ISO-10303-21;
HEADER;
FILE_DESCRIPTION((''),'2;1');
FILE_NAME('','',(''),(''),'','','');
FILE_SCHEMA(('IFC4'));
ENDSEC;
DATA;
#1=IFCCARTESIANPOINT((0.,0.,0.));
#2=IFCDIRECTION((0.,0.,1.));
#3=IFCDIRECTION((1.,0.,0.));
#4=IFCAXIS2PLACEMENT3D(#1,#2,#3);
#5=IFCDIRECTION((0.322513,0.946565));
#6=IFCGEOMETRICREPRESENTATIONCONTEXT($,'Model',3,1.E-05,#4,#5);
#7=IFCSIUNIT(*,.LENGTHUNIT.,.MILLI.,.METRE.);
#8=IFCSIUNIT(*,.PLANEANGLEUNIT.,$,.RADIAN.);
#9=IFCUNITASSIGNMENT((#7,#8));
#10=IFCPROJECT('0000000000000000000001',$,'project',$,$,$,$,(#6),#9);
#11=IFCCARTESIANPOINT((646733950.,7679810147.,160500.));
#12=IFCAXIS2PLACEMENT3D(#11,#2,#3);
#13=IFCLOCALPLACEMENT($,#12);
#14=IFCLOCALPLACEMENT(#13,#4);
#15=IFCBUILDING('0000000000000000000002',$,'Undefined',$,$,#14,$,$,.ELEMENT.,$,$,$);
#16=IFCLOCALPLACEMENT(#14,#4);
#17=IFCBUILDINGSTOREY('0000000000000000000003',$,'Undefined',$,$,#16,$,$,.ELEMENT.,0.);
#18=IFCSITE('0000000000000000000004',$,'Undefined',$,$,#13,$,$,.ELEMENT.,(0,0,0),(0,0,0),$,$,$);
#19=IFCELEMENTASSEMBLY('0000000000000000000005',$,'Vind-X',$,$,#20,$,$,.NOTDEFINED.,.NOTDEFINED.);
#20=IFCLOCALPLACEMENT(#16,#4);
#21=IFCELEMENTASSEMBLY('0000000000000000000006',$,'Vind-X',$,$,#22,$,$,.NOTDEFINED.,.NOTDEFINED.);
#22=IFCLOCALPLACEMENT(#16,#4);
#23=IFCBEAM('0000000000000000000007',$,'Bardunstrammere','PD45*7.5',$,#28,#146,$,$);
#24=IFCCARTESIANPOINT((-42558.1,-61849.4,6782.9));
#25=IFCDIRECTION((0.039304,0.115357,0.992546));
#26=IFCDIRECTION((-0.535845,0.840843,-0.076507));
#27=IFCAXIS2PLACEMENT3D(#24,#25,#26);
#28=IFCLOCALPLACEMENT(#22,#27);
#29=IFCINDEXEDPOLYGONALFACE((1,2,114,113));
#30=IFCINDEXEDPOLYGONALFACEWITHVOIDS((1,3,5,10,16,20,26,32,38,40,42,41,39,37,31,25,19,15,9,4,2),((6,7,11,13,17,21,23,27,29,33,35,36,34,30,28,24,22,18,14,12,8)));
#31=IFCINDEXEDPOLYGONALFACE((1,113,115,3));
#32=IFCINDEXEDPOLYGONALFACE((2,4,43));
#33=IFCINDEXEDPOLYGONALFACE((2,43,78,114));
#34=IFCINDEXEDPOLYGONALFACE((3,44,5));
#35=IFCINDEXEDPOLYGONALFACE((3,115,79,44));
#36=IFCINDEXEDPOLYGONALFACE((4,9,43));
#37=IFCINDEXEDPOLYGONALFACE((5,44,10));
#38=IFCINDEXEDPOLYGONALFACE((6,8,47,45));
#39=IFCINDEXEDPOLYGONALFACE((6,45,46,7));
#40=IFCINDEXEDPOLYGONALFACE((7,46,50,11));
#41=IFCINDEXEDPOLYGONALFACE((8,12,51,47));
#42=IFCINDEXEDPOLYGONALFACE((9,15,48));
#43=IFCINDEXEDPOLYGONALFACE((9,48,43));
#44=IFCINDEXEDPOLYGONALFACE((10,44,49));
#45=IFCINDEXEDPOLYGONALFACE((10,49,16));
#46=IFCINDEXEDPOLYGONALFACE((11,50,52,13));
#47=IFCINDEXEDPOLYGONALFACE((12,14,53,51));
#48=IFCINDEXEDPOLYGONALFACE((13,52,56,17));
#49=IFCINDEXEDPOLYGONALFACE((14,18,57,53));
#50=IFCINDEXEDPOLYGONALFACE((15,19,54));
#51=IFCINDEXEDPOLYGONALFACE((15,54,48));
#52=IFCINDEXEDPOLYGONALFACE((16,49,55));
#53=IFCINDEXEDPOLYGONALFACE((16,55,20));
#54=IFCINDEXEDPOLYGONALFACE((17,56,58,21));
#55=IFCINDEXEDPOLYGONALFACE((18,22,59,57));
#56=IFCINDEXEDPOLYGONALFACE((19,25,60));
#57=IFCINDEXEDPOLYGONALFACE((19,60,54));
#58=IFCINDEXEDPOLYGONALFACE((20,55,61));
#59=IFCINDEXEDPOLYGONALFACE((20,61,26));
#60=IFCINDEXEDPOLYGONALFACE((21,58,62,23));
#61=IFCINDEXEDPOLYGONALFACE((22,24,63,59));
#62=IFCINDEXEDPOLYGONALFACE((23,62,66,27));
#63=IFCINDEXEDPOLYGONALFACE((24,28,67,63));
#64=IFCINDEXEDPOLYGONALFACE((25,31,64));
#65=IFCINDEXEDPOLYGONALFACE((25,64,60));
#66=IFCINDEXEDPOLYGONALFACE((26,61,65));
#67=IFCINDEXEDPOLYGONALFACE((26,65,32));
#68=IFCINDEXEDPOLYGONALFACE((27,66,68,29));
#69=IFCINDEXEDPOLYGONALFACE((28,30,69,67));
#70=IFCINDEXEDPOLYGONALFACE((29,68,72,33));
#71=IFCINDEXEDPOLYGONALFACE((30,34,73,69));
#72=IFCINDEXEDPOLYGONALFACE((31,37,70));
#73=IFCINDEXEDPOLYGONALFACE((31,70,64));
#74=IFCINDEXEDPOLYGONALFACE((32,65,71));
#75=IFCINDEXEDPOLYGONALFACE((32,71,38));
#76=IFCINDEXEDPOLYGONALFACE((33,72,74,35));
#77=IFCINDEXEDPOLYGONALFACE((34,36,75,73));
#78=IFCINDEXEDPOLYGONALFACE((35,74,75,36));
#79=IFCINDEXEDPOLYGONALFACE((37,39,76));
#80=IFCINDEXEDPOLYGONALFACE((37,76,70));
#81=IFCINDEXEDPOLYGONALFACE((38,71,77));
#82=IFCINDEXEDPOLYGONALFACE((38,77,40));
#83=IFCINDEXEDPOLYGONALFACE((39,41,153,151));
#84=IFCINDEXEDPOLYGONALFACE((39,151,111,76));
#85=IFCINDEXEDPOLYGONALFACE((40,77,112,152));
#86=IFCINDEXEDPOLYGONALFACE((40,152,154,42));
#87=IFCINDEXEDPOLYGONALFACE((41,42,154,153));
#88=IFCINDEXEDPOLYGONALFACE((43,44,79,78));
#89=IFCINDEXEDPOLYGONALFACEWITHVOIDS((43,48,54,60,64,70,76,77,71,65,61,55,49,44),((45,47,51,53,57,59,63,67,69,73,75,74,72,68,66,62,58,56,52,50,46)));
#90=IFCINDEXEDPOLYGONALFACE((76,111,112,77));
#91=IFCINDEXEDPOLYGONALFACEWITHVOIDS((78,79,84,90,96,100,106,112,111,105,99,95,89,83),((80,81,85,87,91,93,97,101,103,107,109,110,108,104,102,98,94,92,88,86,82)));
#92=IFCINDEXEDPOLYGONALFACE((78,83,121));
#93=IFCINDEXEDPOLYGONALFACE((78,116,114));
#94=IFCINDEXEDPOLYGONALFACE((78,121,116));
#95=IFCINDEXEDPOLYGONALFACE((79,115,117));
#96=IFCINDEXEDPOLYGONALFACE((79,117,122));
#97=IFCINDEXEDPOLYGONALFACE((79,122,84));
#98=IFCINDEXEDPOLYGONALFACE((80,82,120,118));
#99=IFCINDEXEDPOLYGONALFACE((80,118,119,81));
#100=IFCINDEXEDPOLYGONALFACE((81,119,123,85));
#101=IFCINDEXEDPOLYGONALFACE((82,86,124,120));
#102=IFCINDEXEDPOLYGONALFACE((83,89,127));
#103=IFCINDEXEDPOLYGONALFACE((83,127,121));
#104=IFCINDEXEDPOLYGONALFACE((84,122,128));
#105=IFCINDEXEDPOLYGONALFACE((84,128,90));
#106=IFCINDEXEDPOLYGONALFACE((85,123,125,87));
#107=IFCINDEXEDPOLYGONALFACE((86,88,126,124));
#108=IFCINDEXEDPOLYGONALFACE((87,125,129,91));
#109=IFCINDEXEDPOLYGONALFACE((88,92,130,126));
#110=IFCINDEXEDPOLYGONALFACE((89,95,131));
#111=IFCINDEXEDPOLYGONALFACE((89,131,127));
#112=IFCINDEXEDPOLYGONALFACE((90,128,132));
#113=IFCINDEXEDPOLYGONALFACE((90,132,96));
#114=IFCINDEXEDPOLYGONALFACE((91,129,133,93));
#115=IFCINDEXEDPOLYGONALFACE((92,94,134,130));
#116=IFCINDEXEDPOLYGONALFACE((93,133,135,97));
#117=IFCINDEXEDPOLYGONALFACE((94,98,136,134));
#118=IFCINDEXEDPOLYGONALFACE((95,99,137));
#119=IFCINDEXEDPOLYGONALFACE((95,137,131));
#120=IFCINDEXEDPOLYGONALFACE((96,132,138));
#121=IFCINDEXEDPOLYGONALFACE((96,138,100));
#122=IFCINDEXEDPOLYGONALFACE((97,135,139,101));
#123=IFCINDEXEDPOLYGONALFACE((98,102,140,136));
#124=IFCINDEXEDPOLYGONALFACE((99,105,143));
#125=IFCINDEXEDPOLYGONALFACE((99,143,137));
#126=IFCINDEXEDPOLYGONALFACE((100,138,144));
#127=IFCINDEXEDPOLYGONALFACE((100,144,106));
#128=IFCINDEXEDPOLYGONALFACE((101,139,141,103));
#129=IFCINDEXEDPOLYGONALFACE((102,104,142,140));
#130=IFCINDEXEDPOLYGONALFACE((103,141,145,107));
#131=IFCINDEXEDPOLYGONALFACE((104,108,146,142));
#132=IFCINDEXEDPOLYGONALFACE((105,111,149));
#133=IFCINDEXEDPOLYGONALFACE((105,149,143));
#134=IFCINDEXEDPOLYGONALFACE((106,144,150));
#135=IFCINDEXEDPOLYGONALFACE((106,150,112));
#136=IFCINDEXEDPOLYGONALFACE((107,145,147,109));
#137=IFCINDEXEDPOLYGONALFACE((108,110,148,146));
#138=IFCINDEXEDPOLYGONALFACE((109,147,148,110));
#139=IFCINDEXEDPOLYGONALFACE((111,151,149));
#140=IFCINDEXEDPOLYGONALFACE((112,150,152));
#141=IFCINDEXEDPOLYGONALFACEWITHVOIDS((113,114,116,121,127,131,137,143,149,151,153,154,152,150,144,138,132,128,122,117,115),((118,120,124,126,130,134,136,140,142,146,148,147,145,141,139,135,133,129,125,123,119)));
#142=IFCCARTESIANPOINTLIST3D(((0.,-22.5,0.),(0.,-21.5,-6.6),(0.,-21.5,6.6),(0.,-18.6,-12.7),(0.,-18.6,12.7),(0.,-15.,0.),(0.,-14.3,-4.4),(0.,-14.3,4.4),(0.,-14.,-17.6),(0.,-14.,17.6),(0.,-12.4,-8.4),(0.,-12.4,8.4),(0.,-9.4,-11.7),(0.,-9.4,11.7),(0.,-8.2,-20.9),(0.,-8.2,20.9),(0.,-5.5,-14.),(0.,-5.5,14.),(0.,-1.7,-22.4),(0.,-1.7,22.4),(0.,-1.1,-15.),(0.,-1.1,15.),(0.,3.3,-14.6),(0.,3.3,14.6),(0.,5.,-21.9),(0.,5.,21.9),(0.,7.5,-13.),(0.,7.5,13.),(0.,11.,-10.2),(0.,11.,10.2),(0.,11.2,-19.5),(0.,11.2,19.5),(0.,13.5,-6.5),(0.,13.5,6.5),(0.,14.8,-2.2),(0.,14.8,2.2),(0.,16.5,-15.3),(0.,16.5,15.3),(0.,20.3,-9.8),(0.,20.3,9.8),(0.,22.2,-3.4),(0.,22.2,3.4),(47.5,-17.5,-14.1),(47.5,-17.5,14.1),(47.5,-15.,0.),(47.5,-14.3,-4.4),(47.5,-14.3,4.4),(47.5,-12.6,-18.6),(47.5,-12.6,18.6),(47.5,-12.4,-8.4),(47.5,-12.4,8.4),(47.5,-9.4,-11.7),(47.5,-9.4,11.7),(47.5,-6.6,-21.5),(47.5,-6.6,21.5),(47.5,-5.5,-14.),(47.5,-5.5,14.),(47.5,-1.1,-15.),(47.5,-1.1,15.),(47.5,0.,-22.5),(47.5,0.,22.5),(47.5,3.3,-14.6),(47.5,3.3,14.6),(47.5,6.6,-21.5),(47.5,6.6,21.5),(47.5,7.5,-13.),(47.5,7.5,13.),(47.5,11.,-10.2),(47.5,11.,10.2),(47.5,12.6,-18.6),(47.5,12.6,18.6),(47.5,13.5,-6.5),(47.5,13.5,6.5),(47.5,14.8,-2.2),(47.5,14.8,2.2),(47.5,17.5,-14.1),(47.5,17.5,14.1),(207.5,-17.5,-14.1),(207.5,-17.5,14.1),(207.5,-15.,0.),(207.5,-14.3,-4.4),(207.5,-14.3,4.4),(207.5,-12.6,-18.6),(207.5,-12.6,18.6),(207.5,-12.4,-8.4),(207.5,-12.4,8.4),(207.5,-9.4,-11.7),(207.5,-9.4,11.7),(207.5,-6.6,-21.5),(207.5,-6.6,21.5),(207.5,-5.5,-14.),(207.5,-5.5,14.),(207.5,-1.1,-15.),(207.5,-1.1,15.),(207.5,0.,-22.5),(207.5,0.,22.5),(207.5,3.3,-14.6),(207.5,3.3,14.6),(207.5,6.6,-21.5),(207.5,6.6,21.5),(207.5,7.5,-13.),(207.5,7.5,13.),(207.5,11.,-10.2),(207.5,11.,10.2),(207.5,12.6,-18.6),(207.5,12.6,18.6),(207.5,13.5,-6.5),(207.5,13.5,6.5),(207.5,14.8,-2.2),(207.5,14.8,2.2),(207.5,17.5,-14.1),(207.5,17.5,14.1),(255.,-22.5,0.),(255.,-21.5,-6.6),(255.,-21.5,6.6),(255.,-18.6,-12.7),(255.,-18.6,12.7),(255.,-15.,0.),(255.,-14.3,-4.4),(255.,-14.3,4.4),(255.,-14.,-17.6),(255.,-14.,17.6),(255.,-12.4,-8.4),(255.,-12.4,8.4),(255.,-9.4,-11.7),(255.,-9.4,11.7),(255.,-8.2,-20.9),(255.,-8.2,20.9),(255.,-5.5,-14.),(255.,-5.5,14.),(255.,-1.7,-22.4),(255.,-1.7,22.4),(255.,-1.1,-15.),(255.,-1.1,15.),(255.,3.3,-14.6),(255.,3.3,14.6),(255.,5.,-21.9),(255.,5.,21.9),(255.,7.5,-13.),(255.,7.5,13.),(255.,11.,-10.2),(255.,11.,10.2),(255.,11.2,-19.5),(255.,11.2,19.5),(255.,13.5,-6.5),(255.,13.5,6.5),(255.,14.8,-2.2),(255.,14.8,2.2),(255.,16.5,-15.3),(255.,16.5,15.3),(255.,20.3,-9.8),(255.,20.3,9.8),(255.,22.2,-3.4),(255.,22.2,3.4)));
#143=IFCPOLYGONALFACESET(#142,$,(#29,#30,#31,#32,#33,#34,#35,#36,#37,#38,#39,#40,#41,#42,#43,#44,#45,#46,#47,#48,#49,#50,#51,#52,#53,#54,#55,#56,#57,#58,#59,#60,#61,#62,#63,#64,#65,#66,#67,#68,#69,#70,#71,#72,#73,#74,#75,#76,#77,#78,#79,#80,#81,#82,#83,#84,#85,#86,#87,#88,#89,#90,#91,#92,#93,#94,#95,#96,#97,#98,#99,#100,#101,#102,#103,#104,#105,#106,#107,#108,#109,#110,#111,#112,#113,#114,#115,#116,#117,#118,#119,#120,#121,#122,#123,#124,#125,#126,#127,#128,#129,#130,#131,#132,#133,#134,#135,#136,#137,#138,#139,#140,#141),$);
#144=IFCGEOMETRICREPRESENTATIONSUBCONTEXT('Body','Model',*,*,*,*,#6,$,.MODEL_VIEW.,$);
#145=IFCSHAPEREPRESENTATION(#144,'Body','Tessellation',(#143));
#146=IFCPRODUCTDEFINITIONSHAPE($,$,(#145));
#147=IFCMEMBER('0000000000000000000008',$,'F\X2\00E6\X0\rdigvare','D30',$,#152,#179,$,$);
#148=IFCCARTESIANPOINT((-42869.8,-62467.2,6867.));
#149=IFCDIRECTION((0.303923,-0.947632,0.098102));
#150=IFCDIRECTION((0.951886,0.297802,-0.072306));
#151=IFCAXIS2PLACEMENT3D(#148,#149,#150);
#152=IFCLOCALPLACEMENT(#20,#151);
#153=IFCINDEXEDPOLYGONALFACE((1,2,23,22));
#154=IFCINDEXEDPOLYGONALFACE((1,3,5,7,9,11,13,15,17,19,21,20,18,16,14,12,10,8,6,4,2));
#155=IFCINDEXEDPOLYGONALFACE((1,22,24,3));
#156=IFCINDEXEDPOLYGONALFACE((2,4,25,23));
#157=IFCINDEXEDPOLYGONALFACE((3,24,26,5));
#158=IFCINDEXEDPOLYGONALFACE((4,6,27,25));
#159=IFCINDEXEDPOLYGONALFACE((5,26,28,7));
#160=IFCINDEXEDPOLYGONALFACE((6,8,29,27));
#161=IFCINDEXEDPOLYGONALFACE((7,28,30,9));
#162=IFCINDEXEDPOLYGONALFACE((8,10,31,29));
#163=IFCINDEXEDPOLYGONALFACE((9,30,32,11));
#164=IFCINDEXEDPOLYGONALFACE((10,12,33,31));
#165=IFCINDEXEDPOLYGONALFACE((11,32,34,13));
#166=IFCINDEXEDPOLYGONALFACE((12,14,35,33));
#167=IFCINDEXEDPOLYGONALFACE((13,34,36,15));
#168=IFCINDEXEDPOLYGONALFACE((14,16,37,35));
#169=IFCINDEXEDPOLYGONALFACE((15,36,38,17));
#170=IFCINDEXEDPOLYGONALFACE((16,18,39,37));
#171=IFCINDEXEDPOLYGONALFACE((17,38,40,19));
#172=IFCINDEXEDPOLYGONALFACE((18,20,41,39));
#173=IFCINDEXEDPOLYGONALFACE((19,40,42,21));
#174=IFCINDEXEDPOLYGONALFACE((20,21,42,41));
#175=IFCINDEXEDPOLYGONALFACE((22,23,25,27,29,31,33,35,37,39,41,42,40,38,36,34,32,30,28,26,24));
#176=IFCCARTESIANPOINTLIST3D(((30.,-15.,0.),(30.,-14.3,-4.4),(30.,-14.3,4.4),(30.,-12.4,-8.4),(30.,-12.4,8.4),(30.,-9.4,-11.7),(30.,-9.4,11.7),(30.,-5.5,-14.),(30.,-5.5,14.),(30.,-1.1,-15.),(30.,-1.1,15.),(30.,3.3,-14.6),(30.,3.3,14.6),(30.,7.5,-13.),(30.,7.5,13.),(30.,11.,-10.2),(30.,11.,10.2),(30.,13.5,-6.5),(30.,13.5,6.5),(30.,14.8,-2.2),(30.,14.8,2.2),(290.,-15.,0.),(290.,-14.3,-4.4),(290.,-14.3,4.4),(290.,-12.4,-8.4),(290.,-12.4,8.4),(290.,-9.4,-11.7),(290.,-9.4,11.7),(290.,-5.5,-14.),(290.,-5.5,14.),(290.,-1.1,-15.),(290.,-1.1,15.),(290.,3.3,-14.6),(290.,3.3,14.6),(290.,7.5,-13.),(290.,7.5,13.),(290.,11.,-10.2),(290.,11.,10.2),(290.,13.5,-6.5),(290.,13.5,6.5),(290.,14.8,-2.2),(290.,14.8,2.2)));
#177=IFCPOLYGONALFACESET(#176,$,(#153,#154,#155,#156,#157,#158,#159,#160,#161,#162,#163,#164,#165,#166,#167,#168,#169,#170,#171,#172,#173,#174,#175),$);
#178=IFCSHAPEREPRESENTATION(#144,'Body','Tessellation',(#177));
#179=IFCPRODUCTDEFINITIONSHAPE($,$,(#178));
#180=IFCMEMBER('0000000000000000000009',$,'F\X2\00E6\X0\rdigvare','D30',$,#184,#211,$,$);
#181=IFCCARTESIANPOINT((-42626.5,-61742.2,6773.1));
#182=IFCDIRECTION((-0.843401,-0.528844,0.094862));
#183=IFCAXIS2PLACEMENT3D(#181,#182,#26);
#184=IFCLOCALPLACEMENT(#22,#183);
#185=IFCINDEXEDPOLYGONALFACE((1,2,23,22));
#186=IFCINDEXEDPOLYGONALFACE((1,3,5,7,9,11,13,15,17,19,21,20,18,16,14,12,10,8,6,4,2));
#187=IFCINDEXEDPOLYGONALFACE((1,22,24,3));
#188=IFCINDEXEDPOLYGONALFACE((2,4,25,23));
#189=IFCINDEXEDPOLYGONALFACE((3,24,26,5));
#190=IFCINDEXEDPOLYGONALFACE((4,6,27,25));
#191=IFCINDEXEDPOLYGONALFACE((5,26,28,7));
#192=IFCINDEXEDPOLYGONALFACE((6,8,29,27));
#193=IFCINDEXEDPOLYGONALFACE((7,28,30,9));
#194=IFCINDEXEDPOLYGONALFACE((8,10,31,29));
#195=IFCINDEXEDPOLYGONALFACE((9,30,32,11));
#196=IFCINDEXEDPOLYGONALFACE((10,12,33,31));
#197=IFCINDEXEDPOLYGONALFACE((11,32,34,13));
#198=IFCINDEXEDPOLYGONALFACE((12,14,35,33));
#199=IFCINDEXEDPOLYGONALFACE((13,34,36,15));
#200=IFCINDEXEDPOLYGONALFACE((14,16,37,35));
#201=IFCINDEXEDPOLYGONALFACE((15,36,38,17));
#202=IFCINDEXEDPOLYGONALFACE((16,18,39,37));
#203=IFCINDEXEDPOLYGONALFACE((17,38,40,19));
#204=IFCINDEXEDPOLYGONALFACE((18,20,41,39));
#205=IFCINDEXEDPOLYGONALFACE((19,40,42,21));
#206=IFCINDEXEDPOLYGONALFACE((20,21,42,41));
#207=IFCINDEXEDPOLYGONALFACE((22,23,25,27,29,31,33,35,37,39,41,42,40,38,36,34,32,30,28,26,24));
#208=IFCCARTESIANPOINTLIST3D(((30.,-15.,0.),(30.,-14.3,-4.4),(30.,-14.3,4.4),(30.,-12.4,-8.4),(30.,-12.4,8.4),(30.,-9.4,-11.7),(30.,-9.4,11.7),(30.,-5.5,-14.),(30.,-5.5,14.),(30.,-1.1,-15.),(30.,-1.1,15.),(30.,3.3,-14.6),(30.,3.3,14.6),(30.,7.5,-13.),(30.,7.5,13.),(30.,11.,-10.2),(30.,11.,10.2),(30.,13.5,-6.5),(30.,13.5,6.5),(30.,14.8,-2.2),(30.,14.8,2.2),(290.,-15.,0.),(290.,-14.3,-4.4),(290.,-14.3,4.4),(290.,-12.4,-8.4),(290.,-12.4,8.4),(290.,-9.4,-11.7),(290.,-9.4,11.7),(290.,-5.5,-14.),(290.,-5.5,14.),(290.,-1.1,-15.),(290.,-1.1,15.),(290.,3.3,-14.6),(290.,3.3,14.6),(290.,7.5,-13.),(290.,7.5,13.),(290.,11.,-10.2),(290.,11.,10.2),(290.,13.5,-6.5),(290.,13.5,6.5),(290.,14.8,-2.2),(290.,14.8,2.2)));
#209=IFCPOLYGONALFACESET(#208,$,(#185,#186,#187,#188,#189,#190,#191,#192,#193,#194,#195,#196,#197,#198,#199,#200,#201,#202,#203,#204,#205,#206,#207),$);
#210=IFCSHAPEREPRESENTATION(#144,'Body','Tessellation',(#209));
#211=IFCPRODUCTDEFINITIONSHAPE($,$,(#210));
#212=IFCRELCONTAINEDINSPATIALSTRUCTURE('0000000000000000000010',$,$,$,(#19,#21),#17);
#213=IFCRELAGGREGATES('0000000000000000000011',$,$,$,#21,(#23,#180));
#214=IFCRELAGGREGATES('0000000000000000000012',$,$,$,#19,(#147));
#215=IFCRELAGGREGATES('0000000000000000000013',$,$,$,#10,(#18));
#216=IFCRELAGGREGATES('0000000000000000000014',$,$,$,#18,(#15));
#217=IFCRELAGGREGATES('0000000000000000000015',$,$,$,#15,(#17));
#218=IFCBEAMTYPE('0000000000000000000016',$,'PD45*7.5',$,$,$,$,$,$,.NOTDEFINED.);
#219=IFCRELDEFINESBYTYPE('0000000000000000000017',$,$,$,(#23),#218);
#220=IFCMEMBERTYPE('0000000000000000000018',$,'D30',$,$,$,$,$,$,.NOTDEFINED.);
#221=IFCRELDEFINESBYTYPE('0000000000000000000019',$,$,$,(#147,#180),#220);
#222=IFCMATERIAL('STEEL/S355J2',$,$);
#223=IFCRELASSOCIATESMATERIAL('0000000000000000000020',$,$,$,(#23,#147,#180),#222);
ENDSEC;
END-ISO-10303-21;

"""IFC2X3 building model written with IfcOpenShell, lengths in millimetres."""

from ifc_helpers import new_model, si_unit, direction, frame, origin_with_axes, origin_2d_with_axis, place, context, subcontext, project, spatial, rectangle, circle, hollow_circle, extrude, boolean, clip, halfspace, material, type_object, element, aggregate, save


model = new_model("IFC2X3")

# Units and contexts
model_context = context("Model", 3, precision=1e-05, world=origin_with_axes(), true_north=direction((0.322513, 0.946565)))
body_context = subcontext(model_context, "Body", "Model", "MODEL_VIEW")
ifc_project = project(units=[si_unit("LENGTHUNIT", "METRE", prefix="MILLI"), si_unit("PLANEANGLEUNIT", "RADIAN")], contexts=[model_context])

# Site, building, storey
site_placement = place(None, frame((646733950.0, 7679810147.0, 160500.0), z_axis=(0.0, 0.0, 1.0), x_axis=(1.0, 0.0, 0.0)))
site = spatial("IfcSite", under=ifc_project, at=site_placement, Name="Undefined", CompositionType="ELEMENT", RefLatitude=(0, 0, 0), RefLongitude=(0, 0, 0))
building_placement = place(site_placement, origin_with_axes())
building = spatial("IfcBuilding", under=site, at=building_placement, Name="Undefined", CompositionType="ELEMENT")
storey_placement = place(building_placement, origin_with_axes())
storey = spatial("IfcBuildingStorey", under=building, at=storey_placement, Name="Undefined", CompositionType="ELEMENT", Elevation=0.0)

# Element assemblies, beam
assembly_1_placement = place(storey_placement, origin_with_axes())
assembly_1 = element("IfcElementAssembly", 1, at=assembly_1_placement, inside=storey, Name="Vind-X", AssemblyPlace="NOTDEFINED", PredefinedType="NOTDEFINED")
ifc_material_1 = material(Name="STEEL/S355J2")
beam_type_1 = type_object("IfcBeamType", Name="PD45*7.5", PredefinedType="NOTDEFINED")
assembly_2_placement = place(storey_placement, origin_with_axes())
assembly_2 = element("IfcElementAssembly", 2, at=assembly_2_placement, inside=storey, Name="Vind-X", AssemblyPlace="NOTDEFINED", PredefinedType="NOTDEFINED")
beam_1_placement = place(assembly_2_placement, frame((-42558.1, -61849.4, 6782.9), z_axis=(0.039304, 0.115357, 0.992546), x_axis=(-0.535845, 0.840843, -0.076507)))
beam_1 = element("IfcBeam", 3, at=beam_1_placement, type_object=beam_type_1, material=ifc_material_1, Name="Bardunstrammere", Description="PD45*7.5", context=body_context, shape_type="CSG", body=[
    boolean("DIFFERENCE", extrude(hollow_circle(Radius=22.5, WallThickness=7.5, at=origin_2d_with_axis()), frame((255.0, 0.0, 0.0), z_axis=(-1.0, 0.0, 0.0), x_axis=(0.0, -1.0, 0.0)), (0.0, 0.0, 1.0), 255.0), extrude(rectangle(XDim=35.0, YDim=90.0, at=origin_2d_with_axis()), frame((207.5, 0.0, 0.0), z_axis=(-1.0, 0.0, 0.0), x_axis=(0.0, -1.0, 0.0)), (0.0, 0.0, 1.0), 160.0)),
])

# Members
member_type_1 = type_object("IfcMemberType", Name="D30", PredefinedType="NOTDEFINED")
member_1_placement = place(assembly_1_placement, frame((-42869.8, -62467.2, 6867.0), z_axis=(0.303923, -0.947632, 0.098102), x_axis=(0.951886, 0.297802, -0.072306)))
member_1 = element("IfcMember", 4, at=member_1_placement, type_object=member_type_1, material=ifc_material_1, Name="Færdigvare", Description="D30", context=body_context, shape_type="Clipping", body=[
    clip(extrude(circle(Radius=15.0, at=origin_2d_with_axis()), frame((290.0, 0.0, 0.0), z_axis=(-1.0, 0.0, 0.0), x_axis=(0.0, -1.0, 0.0)), (0.0, 0.0, 1.0), 290.0), halfspace(frame((30.0, 0.0, -15.0), z_axis=(1.0, 0.0, 0.0), x_axis=(0.0, -1.0, 0.0)), True)),
])
member_2_placement = place(assembly_2_placement, frame((-42626.5, -61742.2, 6773.1), z_axis=(-0.843401, -0.528844, 0.094862), x_axis=(-0.535845, 0.840843, -0.076507)))
member_2 = element("IfcMember", 5, at=member_2_placement, type_object=member_type_1, material=ifc_material_1, Name="Færdigvare", Description="D30", context=body_context, shape_type="Clipping", body=[
    clip(extrude(circle(Radius=15.0, at=origin_2d_with_axis()), frame((290.0, 0.0, 0.0), z_axis=(-1.0, 0.0, 0.0), x_axis=(0.0, -1.0, 0.0)), (0.0, 0.0, 1.0), 290.0), halfspace(frame((30.0, 0.0, -15.0), z_axis=(1.0, 0.0, 0.0), x_axis=(0.0, -1.0, 0.0)), True)),
])

aggregate(assembly_2, [beam_1, member_2])
aggregate(assembly_1, [member_1])

save(model, "model.ifc")
